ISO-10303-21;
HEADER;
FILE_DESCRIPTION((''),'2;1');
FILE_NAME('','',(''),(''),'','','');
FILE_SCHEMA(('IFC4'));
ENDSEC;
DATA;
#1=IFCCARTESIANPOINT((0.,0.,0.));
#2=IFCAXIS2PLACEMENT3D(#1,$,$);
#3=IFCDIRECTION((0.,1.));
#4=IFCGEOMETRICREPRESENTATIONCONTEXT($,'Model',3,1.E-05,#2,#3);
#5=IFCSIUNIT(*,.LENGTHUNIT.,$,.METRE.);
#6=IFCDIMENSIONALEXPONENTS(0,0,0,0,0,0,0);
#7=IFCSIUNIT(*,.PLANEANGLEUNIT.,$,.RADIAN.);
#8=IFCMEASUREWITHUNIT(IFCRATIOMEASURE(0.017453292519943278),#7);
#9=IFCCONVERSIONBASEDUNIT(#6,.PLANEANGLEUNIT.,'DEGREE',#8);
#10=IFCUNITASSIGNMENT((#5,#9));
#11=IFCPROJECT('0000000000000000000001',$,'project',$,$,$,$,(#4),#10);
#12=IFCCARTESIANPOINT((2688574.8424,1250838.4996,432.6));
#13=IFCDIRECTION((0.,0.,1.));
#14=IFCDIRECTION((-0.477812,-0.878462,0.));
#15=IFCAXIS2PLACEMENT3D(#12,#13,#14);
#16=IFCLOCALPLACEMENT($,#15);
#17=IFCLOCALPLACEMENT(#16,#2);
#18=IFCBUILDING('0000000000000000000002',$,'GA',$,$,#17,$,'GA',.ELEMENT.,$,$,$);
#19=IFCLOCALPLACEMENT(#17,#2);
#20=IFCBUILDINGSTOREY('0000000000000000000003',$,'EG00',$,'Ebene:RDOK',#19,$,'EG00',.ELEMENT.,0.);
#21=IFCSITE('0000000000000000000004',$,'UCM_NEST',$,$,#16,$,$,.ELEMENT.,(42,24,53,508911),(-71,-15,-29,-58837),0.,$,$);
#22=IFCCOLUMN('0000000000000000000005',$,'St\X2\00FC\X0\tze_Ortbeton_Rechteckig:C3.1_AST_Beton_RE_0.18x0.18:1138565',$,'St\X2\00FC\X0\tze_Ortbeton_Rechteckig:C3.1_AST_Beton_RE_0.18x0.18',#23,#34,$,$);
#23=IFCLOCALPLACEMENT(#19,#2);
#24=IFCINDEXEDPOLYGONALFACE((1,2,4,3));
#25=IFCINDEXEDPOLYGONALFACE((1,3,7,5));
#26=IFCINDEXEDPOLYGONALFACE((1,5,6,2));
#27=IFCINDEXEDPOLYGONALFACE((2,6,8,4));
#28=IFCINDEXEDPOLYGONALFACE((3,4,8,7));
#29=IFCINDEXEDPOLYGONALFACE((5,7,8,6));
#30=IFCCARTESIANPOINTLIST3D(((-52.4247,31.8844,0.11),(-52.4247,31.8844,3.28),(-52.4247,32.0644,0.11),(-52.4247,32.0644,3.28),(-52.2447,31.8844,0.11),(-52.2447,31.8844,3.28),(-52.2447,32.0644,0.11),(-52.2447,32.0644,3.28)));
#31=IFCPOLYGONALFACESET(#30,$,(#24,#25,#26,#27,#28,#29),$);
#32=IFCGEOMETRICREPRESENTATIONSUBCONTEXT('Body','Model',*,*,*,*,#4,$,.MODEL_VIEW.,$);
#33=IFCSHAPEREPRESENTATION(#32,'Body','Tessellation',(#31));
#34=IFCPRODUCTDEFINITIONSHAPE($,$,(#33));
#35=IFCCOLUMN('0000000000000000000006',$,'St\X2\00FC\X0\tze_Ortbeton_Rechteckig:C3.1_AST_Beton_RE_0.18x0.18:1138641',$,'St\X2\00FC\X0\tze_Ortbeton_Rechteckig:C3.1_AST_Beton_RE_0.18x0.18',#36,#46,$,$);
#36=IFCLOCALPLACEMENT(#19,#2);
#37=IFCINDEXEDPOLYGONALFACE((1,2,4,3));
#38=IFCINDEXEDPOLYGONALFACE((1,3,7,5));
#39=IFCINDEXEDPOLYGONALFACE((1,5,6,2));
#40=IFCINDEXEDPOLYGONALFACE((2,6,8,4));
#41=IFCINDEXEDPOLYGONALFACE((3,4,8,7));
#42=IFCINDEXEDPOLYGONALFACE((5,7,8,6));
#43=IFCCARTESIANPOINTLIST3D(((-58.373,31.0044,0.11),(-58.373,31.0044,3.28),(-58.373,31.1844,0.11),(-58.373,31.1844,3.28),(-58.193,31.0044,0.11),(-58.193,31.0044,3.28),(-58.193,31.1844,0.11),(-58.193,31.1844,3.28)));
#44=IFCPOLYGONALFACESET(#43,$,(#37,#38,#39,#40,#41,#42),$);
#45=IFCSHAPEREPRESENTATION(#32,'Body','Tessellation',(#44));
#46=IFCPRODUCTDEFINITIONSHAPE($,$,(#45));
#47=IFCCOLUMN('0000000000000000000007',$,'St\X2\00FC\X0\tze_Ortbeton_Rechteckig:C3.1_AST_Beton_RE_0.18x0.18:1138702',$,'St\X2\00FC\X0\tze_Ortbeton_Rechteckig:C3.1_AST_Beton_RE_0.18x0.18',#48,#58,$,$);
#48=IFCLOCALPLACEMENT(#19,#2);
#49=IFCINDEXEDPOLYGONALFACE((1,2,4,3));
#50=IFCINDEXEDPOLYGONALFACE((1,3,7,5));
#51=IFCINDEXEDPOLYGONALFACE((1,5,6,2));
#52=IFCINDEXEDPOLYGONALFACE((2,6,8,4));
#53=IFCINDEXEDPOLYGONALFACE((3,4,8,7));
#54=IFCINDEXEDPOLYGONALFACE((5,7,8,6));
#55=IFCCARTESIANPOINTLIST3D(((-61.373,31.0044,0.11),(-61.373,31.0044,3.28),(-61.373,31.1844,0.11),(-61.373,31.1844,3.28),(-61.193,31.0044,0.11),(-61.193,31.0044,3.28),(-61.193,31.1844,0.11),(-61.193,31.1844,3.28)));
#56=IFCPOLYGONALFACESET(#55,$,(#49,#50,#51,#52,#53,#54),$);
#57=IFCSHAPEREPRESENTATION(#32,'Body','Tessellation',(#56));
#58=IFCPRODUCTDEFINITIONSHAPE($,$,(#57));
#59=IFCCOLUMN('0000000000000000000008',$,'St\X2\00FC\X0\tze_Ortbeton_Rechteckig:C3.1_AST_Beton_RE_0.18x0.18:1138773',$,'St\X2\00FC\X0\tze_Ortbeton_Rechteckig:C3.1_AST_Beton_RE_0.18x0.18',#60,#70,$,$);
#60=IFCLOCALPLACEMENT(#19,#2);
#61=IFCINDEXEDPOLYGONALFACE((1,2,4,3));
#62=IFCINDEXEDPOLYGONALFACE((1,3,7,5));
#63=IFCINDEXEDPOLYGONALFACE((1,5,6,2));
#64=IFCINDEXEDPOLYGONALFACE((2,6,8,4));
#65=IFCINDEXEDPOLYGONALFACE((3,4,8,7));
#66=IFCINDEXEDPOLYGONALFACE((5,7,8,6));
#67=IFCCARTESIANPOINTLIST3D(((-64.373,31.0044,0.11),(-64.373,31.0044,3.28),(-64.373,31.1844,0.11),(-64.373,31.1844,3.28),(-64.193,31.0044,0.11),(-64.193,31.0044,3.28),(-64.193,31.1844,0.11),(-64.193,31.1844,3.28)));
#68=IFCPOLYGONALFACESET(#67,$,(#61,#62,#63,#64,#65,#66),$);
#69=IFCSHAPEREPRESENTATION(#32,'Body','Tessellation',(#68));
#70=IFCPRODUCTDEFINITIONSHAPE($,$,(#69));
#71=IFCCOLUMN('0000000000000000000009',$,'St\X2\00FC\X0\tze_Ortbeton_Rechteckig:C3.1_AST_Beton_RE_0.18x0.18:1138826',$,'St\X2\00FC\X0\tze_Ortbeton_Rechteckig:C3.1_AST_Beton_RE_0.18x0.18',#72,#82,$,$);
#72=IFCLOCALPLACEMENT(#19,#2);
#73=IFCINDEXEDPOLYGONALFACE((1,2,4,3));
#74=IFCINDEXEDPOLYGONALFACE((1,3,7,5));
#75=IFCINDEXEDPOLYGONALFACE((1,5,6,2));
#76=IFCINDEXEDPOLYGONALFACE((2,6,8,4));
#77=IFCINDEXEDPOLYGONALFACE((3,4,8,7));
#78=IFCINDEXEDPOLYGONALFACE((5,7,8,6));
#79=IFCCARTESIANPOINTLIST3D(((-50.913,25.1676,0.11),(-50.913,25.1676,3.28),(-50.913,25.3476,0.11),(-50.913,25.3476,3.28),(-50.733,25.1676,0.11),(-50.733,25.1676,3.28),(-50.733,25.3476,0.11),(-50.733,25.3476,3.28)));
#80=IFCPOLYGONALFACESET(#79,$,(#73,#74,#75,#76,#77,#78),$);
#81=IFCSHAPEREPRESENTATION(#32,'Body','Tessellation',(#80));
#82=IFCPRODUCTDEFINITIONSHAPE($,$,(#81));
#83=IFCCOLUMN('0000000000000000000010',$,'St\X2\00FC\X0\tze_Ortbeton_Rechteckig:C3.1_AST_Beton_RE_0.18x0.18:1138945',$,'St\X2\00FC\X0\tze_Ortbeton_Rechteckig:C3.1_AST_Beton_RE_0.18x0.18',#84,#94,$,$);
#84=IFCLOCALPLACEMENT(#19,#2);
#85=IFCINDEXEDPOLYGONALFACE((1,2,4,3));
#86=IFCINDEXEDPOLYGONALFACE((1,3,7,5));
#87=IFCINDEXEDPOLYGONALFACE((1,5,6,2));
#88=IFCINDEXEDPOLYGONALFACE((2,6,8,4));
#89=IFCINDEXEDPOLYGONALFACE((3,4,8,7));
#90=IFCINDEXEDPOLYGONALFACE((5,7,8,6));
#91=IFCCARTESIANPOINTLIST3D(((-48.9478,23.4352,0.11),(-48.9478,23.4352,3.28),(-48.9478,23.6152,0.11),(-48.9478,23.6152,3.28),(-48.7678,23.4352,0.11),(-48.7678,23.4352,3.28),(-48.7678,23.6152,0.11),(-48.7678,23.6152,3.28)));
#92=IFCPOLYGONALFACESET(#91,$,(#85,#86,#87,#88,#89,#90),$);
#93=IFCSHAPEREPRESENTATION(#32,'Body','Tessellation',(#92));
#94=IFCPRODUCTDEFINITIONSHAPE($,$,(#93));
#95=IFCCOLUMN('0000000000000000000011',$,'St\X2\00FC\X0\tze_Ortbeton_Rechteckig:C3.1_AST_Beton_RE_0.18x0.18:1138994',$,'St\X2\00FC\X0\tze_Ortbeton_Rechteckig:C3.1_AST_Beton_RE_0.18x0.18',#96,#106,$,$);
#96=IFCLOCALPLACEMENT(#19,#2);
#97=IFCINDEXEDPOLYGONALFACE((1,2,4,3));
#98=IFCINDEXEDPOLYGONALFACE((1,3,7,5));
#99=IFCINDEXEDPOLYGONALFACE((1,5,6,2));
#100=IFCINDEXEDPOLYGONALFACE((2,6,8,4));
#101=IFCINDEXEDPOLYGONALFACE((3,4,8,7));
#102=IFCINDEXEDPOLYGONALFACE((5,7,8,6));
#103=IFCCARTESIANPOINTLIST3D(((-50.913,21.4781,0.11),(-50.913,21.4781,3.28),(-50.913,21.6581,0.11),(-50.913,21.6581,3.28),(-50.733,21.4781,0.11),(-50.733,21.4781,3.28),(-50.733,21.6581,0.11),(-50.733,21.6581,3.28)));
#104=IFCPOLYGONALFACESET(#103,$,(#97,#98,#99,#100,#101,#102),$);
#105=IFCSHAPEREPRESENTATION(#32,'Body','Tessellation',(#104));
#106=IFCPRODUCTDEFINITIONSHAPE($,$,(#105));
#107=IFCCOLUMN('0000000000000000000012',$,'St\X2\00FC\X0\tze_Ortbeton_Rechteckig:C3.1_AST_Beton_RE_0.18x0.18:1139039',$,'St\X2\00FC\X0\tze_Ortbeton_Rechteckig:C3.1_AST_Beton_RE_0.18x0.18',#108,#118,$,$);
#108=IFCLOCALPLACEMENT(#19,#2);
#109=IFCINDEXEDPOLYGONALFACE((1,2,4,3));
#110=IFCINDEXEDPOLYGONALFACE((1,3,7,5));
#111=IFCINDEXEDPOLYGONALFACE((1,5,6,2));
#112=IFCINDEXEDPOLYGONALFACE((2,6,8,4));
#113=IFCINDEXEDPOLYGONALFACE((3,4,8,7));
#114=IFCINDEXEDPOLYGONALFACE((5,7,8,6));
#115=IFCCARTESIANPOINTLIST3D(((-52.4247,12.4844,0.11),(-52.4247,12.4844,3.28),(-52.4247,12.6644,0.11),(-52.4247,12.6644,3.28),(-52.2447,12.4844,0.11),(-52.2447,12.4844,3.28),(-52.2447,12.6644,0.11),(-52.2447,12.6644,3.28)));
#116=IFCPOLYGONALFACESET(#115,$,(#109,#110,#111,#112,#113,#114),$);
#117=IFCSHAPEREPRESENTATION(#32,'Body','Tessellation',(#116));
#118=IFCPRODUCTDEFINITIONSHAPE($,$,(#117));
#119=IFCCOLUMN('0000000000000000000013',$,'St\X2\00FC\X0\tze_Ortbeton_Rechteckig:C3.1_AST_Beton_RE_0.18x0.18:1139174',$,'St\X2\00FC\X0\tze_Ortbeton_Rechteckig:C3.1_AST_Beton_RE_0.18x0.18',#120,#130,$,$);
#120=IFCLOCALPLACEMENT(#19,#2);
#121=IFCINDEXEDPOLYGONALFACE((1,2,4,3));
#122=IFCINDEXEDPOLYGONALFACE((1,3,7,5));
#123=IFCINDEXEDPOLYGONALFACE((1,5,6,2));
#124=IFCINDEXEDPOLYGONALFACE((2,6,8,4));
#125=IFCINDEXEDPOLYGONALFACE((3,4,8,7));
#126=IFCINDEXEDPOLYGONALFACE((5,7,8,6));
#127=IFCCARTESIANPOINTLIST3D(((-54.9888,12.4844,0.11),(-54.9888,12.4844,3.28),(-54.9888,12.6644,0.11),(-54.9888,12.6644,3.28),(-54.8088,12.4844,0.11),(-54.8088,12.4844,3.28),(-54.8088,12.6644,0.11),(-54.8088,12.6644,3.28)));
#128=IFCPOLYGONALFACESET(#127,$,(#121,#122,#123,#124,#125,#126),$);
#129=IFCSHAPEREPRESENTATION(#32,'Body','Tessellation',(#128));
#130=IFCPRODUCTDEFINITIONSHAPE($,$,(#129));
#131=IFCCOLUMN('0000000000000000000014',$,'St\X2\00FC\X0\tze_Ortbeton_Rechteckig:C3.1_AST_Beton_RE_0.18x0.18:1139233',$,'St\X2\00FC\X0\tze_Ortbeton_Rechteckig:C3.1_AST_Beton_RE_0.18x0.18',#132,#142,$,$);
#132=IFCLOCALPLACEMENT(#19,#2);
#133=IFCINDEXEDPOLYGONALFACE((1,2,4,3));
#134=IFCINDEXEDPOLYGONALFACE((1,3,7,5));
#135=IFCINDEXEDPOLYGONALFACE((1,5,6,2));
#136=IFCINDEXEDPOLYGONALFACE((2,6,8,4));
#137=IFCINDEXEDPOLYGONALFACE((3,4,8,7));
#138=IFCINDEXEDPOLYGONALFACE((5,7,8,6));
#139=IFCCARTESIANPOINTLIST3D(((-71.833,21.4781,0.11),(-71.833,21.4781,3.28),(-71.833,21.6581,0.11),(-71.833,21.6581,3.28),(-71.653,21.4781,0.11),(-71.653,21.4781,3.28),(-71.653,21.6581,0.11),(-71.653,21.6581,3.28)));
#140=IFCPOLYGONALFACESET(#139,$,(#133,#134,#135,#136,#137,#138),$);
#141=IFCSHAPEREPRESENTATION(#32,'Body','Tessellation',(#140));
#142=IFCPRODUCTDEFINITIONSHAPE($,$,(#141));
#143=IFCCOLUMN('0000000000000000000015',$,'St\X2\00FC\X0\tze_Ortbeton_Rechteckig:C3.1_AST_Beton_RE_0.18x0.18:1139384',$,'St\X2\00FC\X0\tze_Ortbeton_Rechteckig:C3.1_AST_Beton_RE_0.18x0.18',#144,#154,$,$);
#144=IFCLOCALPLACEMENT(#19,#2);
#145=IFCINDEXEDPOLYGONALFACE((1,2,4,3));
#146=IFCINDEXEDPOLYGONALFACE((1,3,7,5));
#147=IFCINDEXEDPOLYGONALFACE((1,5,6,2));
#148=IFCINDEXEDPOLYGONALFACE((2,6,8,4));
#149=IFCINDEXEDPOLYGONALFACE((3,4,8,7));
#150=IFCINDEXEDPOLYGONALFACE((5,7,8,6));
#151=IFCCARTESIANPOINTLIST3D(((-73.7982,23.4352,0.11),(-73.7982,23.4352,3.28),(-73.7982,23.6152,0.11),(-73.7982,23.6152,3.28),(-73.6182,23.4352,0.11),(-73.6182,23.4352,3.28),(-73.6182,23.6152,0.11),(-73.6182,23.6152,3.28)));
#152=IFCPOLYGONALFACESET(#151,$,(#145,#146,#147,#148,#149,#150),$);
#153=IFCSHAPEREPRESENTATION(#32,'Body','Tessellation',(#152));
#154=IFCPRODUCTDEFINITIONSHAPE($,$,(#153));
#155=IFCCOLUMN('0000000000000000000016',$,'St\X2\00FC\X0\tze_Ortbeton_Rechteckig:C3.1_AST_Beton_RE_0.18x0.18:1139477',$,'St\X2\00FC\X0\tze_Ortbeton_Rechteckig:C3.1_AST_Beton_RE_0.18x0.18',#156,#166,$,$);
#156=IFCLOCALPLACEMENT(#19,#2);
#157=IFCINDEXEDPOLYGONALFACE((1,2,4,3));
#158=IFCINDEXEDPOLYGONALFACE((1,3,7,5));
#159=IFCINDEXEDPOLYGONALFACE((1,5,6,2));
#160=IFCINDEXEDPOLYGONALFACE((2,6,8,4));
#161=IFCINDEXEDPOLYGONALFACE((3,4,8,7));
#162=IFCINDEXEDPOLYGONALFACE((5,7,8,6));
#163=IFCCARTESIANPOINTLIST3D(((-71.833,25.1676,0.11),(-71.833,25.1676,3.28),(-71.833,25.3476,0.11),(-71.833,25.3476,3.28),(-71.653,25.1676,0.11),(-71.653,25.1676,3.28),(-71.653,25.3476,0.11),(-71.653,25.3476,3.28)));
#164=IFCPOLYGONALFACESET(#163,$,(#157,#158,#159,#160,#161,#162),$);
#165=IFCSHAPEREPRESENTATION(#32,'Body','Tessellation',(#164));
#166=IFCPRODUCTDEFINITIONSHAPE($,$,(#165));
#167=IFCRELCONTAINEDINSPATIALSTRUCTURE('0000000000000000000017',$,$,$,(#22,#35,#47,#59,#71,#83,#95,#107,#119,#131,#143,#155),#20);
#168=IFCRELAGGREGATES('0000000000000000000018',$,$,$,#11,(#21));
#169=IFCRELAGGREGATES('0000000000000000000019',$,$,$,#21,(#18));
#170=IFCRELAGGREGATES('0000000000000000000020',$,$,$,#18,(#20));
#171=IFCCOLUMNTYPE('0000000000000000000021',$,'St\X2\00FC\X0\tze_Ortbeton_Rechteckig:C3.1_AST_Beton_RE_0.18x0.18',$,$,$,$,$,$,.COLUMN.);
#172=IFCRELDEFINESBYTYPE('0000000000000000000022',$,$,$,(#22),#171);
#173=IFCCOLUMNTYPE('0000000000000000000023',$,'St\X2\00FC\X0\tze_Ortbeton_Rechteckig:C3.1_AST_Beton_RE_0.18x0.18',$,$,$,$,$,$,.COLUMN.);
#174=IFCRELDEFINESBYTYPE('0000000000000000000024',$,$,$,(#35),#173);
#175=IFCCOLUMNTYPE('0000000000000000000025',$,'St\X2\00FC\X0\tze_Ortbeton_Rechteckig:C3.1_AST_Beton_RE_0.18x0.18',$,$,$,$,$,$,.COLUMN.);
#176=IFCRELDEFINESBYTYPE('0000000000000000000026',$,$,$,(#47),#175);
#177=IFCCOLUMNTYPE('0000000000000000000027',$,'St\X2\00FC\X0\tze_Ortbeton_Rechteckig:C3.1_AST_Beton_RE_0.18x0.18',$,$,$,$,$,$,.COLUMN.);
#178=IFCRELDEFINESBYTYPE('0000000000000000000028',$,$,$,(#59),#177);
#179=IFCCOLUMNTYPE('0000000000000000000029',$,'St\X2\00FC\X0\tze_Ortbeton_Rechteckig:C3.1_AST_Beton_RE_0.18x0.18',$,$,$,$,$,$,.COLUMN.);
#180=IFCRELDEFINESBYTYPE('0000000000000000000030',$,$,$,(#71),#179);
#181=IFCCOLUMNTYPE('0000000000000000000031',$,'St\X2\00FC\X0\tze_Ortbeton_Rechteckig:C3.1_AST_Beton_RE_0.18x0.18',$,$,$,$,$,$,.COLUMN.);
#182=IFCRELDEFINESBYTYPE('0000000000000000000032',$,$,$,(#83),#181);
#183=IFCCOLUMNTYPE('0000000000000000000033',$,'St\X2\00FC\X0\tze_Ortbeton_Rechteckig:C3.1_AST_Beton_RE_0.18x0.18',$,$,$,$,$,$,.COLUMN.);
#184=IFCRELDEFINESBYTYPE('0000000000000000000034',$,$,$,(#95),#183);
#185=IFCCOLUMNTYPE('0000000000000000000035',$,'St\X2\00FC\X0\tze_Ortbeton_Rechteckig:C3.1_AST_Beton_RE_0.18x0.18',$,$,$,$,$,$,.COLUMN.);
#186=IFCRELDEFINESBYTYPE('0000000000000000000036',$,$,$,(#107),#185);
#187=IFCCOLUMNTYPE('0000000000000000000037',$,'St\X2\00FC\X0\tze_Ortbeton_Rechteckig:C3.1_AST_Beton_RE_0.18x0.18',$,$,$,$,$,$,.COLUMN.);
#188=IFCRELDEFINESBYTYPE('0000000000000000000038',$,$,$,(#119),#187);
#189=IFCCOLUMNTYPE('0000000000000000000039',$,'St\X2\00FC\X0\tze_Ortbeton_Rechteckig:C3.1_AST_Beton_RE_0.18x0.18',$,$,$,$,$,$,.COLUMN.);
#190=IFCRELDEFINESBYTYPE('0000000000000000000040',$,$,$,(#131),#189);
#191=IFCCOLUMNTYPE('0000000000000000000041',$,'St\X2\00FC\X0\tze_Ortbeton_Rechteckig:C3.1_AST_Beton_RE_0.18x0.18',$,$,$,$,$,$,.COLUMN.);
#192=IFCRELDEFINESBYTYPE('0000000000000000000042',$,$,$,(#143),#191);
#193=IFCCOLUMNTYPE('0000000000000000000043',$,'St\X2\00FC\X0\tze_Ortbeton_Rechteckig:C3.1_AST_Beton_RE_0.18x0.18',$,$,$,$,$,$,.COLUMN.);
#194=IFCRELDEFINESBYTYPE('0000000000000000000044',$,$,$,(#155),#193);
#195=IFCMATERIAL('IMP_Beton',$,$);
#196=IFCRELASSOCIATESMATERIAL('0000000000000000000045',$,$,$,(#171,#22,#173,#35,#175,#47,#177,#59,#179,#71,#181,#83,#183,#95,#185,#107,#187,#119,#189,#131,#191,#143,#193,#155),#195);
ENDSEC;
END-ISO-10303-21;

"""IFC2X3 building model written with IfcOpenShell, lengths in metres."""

from ifc_helpers import new_model, entity, si_unit, converted_unit, direction, frame, frame_2d, origin, origin_2d_with_axis, place, context, subcontext, project, spatial, rectangle, extrude, source, transform, mapped, material, type_object, type_shapes, element, save


model = new_model("IFC2X3")

# Units and contexts
model_context = context("Model", 3, precision=1e-05, world=origin(), true_north=direction((0.0, 1.0)))
body_context = subcontext(model_context, "Body", "Model", "MODEL_VIEW")
ifc_project = project(units=[si_unit("LENGTHUNIT", "METRE"), converted_unit("PLANEANGLEUNIT", "DEGREE", entity("IfcRatioMeasure", 0.017453292519943278), si_unit("PLANEANGLEUNIT", "RADIAN"), dimensions=[0, 0, 0, 0, 0, 0, 0])], contexts=[model_context])

# Site, building, storey
site_placement = place(None, frame((2688574.8424, 1250838.4996, 432.6), z_axis=(0.0, 0.0, 1.0), x_axis=(-0.477812, -0.878462, 0.0)))
site = spatial("IfcSite", under=ifc_project, at=site_placement, Name="UCM_NEST", CompositionType="ELEMENT", RefLatitude=(42, 24, 53, 508911), RefLongitude=(-71, -15, -29, -58837), RefElevation=0.0)
building_placement = place(site_placement, origin())
building = spatial("IfcBuilding", under=site, at=building_placement, Name="GA", LongName="GA", CompositionType="ELEMENT")
storey_placement = place(building_placement, origin())
storey = spatial("IfcBuildingStorey", under=building, at=storey_placement, Name="EG00", ObjectType="Ebene:RDOK", LongName="EG00", CompositionType="ELEMENT", Elevation=0.0)

# Columns
ifc_material_1 = material(Name="IMP_Beton")
column_type_1 = type_object("IfcColumnType", Name="Stütze_Ortbeton_Rechteckig:C3.1_AST_Beton_RE_0.18x0.18", PredefinedType="COLUMN", material=ifc_material_1)
shared_shape_1 = source(origin(), body_context, "Body", "SweptSolid", [
    extrude(rectangle(XDim=0.18, YDim=0.18, at=origin_2d_with_axis()), frame((-52.3347, 31.9744, 0.11), z_axis=(0.0, 0.0, 1.0), x_axis=(0.0, -1.0, 0.0)), (0.0, 0.0, 1.0), 3.17),
])
type_shapes(column_type_1, [shared_shape_1])
column_1_placement = place(storey_placement, origin())
element("IfcColumn", 1, at=column_1_placement, inside=storey, type_object=column_type_1, material=ifc_material_1, Name="Stütze_Ortbeton_Rechteckig:C3.1_AST_Beton_RE_0.18x0.18:1138565", ObjectType="Stütze_Ortbeton_Rechteckig:C3.1_AST_Beton_RE_0.18x0.18", context=body_context, shape_type="MappedRepresentation", body=[
    mapped(shared_shape_1, transform((0.0, 0.0, 0.0), scale=1.0)),
])
column_type_2 = type_object("IfcColumnType", Name="Stütze_Ortbeton_Rechteckig:C3.1_AST_Beton_RE_0.18x0.18", PredefinedType="COLUMN", material=ifc_material_1)
shared_shape_2 = source(origin(), body_context, "Body", "SweptSolid", [
    extrude(rectangle(XDim=0.18, YDim=0.18, at=frame_2d((0.0, 0.0), x_axis=(1.0, 0.0))), frame((-58.283, 31.0944, 0.11), z_axis=(0.0, 0.0, 1.0), x_axis=(0.0, -1.0, 0.0)), (0.0, 0.0, 1.0), 3.17),
])
type_shapes(column_type_2, [shared_shape_2])
column_2_placement = place(storey_placement, origin())
element("IfcColumn", 2, at=column_2_placement, inside=storey, type_object=column_type_2, material=ifc_material_1, Name="Stütze_Ortbeton_Rechteckig:C3.1_AST_Beton_RE_0.18x0.18:1138641", ObjectType="Stütze_Ortbeton_Rechteckig:C3.1_AST_Beton_RE_0.18x0.18", context=body_context, shape_type="MappedRepresentation", body=[
    mapped(shared_shape_2, transform((0.0, 0.0, 0.0), scale=1.0)),
])
column_type_3 = type_object("IfcColumnType", Name="Stütze_Ortbeton_Rechteckig:C3.1_AST_Beton_RE_0.18x0.18", PredefinedType="COLUMN", material=ifc_material_1)
shared_shape_3 = source(origin(), body_context, "Body", "SweptSolid", [
    extrude(rectangle(XDim=0.18, YDim=0.18, at=frame_2d((0.0, 0.0), x_axis=(1.0, 0.0))), frame((-61.283, 31.0944, 0.11), z_axis=(0.0, 0.0, 1.0), x_axis=(0.0, -1.0, 0.0)), (0.0, 0.0, 1.0), 3.17),
])
type_shapes(column_type_3, [shared_shape_3])
column_3_placement = place(storey_placement, origin())
element("IfcColumn", 3, at=column_3_placement, inside=storey, type_object=column_type_3, material=ifc_material_1, Name="Stütze_Ortbeton_Rechteckig:C3.1_AST_Beton_RE_0.18x0.18:1138702", ObjectType="Stütze_Ortbeton_Rechteckig:C3.1_AST_Beton_RE_0.18x0.18", context=body_context, shape_type="MappedRepresentation", body=[
    mapped(shared_shape_3, transform((0.0, 0.0, 0.0), scale=1.0)),
])
column_type_4 = type_object("IfcColumnType", Name="Stütze_Ortbeton_Rechteckig:C3.1_AST_Beton_RE_0.18x0.18", PredefinedType="COLUMN", material=ifc_material_1)
shared_shape_4 = source(origin(), body_context, "Body", "SweptSolid", [
    extrude(rectangle(XDim=0.18, YDim=0.18, at=frame_2d((0.0, 0.0), x_axis=(1.0, 0.0))), frame((-64.283, 31.0944, 0.11), z_axis=(0.0, 0.0, 1.0), x_axis=(0.0, -1.0, 0.0)), (0.0, 0.0, 1.0), 3.17),
])
type_shapes(column_type_4, [shared_shape_4])
column_4_placement = place(storey_placement, origin())
element("IfcColumn", 4, at=column_4_placement, inside=storey, type_object=column_type_4, material=ifc_material_1, Name="Stütze_Ortbeton_Rechteckig:C3.1_AST_Beton_RE_0.18x0.18:1138773", ObjectType="Stütze_Ortbeton_Rechteckig:C3.1_AST_Beton_RE_0.18x0.18", context=body_context, shape_type="MappedRepresentation", body=[
    mapped(shared_shape_4, transform((0.0, 0.0, 0.0), scale=1.0)),
])
column_type_5 = type_object("IfcColumnType", Name="Stütze_Ortbeton_Rechteckig:C3.1_AST_Beton_RE_0.18x0.18", PredefinedType="COLUMN", material=ifc_material_1)
shared_shape_5 = source(origin(), body_context, "Body", "SweptSolid", [
    extrude(rectangle(XDim=0.18, YDim=0.18, at=origin_2d_with_axis()), frame((-50.823, 25.2576, 0.11), z_axis=(0.0, 0.0, 1.0), x_axis=(0.0, -1.0, 0.0)), (0.0, 0.0, 1.0), 3.17),
])
type_shapes(column_type_5, [shared_shape_5])
column_5_placement = place(storey_placement, origin())
element("IfcColumn", 5, at=column_5_placement, inside=storey, type_object=column_type_5, material=ifc_material_1, Name="Stütze_Ortbeton_Rechteckig:C3.1_AST_Beton_RE_0.18x0.18:1138826", ObjectType="Stütze_Ortbeton_Rechteckig:C3.1_AST_Beton_RE_0.18x0.18", context=body_context, shape_type="MappedRepresentation", body=[
    mapped(shared_shape_5, transform((0.0, 0.0, 0.0), scale=1.0)),
])
column_type_6 = type_object("IfcColumnType", Name="Stütze_Ortbeton_Rechteckig:C3.1_AST_Beton_RE_0.18x0.18", PredefinedType="COLUMN", material=ifc_material_1)
shared_shape_6 = source(origin(), body_context, "Body", "SweptSolid", [
    extrude(rectangle(XDim=0.18, YDim=0.18, at=origin_2d_with_axis()), frame((-48.8578, 23.5252, 0.11), z_axis=(0.0, 0.0, 1.0), x_axis=(0.0, -1.0, 0.0)), (0.0, 0.0, 1.0), 3.17),
])
type_shapes(column_type_6, [shared_shape_6])
column_6_placement = place(storey_placement, origin())
element("IfcColumn", 6, at=column_6_placement, inside=storey, type_object=column_type_6, material=ifc_material_1, Name="Stütze_Ortbeton_Rechteckig:C3.1_AST_Beton_RE_0.18x0.18:1138945", ObjectType="Stütze_Ortbeton_Rechteckig:C3.1_AST_Beton_RE_0.18x0.18", context=body_context, shape_type="MappedRepresentation", body=[
    mapped(shared_shape_6, transform((0.0, 0.0, 0.0), scale=1.0)),
])
column_type_7 = type_object("IfcColumnType", Name="Stütze_Ortbeton_Rechteckig:C3.1_AST_Beton_RE_0.18x0.18", PredefinedType="COLUMN", material=ifc_material_1)
shared_shape_7 = source(origin(), body_context, "Body", "SweptSolid", [
    extrude(rectangle(XDim=0.18, YDim=0.18, at=origin_2d_with_axis()), frame((-50.823, 21.5681, 0.11), z_axis=(0.0, 0.0, 1.0), x_axis=(0.0, -1.0, 0.0)), (0.0, 0.0, 1.0), 3.17),
])
type_shapes(column_type_7, [shared_shape_7])
column_7_placement = place(storey_placement, origin())
element("IfcColumn", 7, at=column_7_placement, inside=storey, type_object=column_type_7, material=ifc_material_1, Name="Stütze_Ortbeton_Rechteckig:C3.1_AST_Beton_RE_0.18x0.18:1138994", ObjectType="Stütze_Ortbeton_Rechteckig:C3.1_AST_Beton_RE_0.18x0.18", context=body_context, shape_type="MappedRepresentation", body=[
    mapped(shared_shape_7, transform((0.0, 0.0, 0.0), scale=1.0)),
])
column_type_8 = type_object("IfcColumnType", Name="Stütze_Ortbeton_Rechteckig:C3.1_AST_Beton_RE_0.18x0.18", PredefinedType="COLUMN", material=ifc_material_1)
shared_shape_8 = source(origin(), body_context, "Body", "SweptSolid", [
    extrude(rectangle(XDim=0.18, YDim=0.18, at=origin_2d_with_axis()), frame((-52.3347, 12.5744, 0.11), z_axis=(0.0, 0.0, 1.0), x_axis=(0.0, -1.0, 0.0)), (0.0, 0.0, 1.0), 3.17),
])
type_shapes(column_type_8, [shared_shape_8])
column_8_placement = place(storey_placement, origin())
element("IfcColumn", 8, at=column_8_placement, inside=storey, type_object=column_type_8, material=ifc_material_1, Name="Stütze_Ortbeton_Rechteckig:C3.1_AST_Beton_RE_0.18x0.18:1139039", ObjectType="Stütze_Ortbeton_Rechteckig:C3.1_AST_Beton_RE_0.18x0.18", context=body_context, shape_type="MappedRepresentation", body=[
    mapped(shared_shape_8, transform((0.0, 0.0, 0.0), scale=1.0)),
])
column_type_9 = type_object("IfcColumnType", Name="Stütze_Ortbeton_Rechteckig:C3.1_AST_Beton_RE_0.18x0.18", PredefinedType="COLUMN", material=ifc_material_1)
shared_shape_9 = source(origin(), body_context, "Body", "SweptSolid", [
    extrude(rectangle(XDim=0.18, YDim=0.18, at=origin_2d_with_axis()), frame((-54.8988, 12.5744, 0.11), z_axis=(0.0, 0.0, 1.0), x_axis=(0.0, -1.0, 0.0)), (0.0, 0.0, 1.0), 3.17),
])
type_shapes(column_type_9, [shared_shape_9])
column_9_placement = place(storey_placement, origin())
element("IfcColumn", 9, at=column_9_placement, inside=storey, type_object=column_type_9, material=ifc_material_1, Name="Stütze_Ortbeton_Rechteckig:C3.1_AST_Beton_RE_0.18x0.18:1139174", ObjectType="Stütze_Ortbeton_Rechteckig:C3.1_AST_Beton_RE_0.18x0.18", context=body_context, shape_type="MappedRepresentation", body=[
    mapped(shared_shape_9, transform((0.0, 0.0, 0.0), scale=1.0)),
])
column_type_10 = type_object("IfcColumnType", Name="Stütze_Ortbeton_Rechteckig:C3.1_AST_Beton_RE_0.18x0.18", PredefinedType="COLUMN", material=ifc_material_1)
shared_shape_10 = source(origin(), body_context, "Body", "SweptSolid", [
    extrude(rectangle(XDim=0.18, YDim=0.18, at=origin_2d_with_axis()), frame((-71.743, 21.5681, 0.11), z_axis=(0.0, 0.0, 1.0), x_axis=(0.0, -1.0, 0.0)), (0.0, 0.0, 1.0), 3.17),
])
type_shapes(column_type_10, [shared_shape_10])
column_10_placement = place(storey_placement, origin())
element("IfcColumn", 10, at=column_10_placement, inside=storey, type_object=column_type_10, material=ifc_material_1, Name="Stütze_Ortbeton_Rechteckig:C3.1_AST_Beton_RE_0.18x0.18:1139233", ObjectType="Stütze_Ortbeton_Rechteckig:C3.1_AST_Beton_RE_0.18x0.18", context=body_context, shape_type="MappedRepresentation", body=[
    mapped(shared_shape_10, transform((0.0, 0.0, 0.0), scale=1.0)),
])
column_type_11 = type_object("IfcColumnType", Name="Stütze_Ortbeton_Rechteckig:C3.1_AST_Beton_RE_0.18x0.18", PredefinedType="COLUMN", material=ifc_material_1)
shared_shape_11 = source(origin(), body_context, "Body", "SweptSolid", [
    extrude(rectangle(XDim=0.18, YDim=0.18, at=origin_2d_with_axis()), frame((-73.7082, 23.5252, 0.11), z_axis=(0.0, 0.0, 1.0), x_axis=(0.0, -1.0, 0.0)), (0.0, 0.0, 1.0), 3.17),
])
type_shapes(column_type_11, [shared_shape_11])
column_11_placement = place(storey_placement, origin())
element("IfcColumn", 11, at=column_11_placement, inside=storey, type_object=column_type_11, material=ifc_material_1, Name="Stütze_Ortbeton_Rechteckig:C3.1_AST_Beton_RE_0.18x0.18:1139384", ObjectType="Stütze_Ortbeton_Rechteckig:C3.1_AST_Beton_RE_0.18x0.18", context=body_context, shape_type="MappedRepresentation", body=[
    mapped(shared_shape_11, transform((0.0, 0.0, 0.0), scale=1.0)),
])
column_type_12 = type_object("IfcColumnType", Name="Stütze_Ortbeton_Rechteckig:C3.1_AST_Beton_RE_0.18x0.18", PredefinedType="COLUMN", material=ifc_material_1)
shared_shape_12 = source(origin(), body_context, "Body", "SweptSolid", [
    extrude(rectangle(XDim=0.18, YDim=0.18, at=origin_2d_with_axis()), frame((-71.743, 25.2576, 0.11), z_axis=(0.0, 0.0, 1.0), x_axis=(0.0, -1.0, 0.0)), (0.0, 0.0, 1.0), 3.17),
])
type_shapes(column_type_12, [shared_shape_12])
column_12_placement = place(storey_placement, origin())
element("IfcColumn", 12, at=column_12_placement, inside=storey, type_object=column_type_12, material=ifc_material_1, Name="Stütze_Ortbeton_Rechteckig:C3.1_AST_Beton_RE_0.18x0.18:1139477", ObjectType="Stütze_Ortbeton_Rechteckig:C3.1_AST_Beton_RE_0.18x0.18", context=body_context, shape_type="MappedRepresentation", body=[
    mapped(shared_shape_12, transform((0.0, 0.0, 0.0), scale=1.0)),
])

save(model, "model.ifc")
